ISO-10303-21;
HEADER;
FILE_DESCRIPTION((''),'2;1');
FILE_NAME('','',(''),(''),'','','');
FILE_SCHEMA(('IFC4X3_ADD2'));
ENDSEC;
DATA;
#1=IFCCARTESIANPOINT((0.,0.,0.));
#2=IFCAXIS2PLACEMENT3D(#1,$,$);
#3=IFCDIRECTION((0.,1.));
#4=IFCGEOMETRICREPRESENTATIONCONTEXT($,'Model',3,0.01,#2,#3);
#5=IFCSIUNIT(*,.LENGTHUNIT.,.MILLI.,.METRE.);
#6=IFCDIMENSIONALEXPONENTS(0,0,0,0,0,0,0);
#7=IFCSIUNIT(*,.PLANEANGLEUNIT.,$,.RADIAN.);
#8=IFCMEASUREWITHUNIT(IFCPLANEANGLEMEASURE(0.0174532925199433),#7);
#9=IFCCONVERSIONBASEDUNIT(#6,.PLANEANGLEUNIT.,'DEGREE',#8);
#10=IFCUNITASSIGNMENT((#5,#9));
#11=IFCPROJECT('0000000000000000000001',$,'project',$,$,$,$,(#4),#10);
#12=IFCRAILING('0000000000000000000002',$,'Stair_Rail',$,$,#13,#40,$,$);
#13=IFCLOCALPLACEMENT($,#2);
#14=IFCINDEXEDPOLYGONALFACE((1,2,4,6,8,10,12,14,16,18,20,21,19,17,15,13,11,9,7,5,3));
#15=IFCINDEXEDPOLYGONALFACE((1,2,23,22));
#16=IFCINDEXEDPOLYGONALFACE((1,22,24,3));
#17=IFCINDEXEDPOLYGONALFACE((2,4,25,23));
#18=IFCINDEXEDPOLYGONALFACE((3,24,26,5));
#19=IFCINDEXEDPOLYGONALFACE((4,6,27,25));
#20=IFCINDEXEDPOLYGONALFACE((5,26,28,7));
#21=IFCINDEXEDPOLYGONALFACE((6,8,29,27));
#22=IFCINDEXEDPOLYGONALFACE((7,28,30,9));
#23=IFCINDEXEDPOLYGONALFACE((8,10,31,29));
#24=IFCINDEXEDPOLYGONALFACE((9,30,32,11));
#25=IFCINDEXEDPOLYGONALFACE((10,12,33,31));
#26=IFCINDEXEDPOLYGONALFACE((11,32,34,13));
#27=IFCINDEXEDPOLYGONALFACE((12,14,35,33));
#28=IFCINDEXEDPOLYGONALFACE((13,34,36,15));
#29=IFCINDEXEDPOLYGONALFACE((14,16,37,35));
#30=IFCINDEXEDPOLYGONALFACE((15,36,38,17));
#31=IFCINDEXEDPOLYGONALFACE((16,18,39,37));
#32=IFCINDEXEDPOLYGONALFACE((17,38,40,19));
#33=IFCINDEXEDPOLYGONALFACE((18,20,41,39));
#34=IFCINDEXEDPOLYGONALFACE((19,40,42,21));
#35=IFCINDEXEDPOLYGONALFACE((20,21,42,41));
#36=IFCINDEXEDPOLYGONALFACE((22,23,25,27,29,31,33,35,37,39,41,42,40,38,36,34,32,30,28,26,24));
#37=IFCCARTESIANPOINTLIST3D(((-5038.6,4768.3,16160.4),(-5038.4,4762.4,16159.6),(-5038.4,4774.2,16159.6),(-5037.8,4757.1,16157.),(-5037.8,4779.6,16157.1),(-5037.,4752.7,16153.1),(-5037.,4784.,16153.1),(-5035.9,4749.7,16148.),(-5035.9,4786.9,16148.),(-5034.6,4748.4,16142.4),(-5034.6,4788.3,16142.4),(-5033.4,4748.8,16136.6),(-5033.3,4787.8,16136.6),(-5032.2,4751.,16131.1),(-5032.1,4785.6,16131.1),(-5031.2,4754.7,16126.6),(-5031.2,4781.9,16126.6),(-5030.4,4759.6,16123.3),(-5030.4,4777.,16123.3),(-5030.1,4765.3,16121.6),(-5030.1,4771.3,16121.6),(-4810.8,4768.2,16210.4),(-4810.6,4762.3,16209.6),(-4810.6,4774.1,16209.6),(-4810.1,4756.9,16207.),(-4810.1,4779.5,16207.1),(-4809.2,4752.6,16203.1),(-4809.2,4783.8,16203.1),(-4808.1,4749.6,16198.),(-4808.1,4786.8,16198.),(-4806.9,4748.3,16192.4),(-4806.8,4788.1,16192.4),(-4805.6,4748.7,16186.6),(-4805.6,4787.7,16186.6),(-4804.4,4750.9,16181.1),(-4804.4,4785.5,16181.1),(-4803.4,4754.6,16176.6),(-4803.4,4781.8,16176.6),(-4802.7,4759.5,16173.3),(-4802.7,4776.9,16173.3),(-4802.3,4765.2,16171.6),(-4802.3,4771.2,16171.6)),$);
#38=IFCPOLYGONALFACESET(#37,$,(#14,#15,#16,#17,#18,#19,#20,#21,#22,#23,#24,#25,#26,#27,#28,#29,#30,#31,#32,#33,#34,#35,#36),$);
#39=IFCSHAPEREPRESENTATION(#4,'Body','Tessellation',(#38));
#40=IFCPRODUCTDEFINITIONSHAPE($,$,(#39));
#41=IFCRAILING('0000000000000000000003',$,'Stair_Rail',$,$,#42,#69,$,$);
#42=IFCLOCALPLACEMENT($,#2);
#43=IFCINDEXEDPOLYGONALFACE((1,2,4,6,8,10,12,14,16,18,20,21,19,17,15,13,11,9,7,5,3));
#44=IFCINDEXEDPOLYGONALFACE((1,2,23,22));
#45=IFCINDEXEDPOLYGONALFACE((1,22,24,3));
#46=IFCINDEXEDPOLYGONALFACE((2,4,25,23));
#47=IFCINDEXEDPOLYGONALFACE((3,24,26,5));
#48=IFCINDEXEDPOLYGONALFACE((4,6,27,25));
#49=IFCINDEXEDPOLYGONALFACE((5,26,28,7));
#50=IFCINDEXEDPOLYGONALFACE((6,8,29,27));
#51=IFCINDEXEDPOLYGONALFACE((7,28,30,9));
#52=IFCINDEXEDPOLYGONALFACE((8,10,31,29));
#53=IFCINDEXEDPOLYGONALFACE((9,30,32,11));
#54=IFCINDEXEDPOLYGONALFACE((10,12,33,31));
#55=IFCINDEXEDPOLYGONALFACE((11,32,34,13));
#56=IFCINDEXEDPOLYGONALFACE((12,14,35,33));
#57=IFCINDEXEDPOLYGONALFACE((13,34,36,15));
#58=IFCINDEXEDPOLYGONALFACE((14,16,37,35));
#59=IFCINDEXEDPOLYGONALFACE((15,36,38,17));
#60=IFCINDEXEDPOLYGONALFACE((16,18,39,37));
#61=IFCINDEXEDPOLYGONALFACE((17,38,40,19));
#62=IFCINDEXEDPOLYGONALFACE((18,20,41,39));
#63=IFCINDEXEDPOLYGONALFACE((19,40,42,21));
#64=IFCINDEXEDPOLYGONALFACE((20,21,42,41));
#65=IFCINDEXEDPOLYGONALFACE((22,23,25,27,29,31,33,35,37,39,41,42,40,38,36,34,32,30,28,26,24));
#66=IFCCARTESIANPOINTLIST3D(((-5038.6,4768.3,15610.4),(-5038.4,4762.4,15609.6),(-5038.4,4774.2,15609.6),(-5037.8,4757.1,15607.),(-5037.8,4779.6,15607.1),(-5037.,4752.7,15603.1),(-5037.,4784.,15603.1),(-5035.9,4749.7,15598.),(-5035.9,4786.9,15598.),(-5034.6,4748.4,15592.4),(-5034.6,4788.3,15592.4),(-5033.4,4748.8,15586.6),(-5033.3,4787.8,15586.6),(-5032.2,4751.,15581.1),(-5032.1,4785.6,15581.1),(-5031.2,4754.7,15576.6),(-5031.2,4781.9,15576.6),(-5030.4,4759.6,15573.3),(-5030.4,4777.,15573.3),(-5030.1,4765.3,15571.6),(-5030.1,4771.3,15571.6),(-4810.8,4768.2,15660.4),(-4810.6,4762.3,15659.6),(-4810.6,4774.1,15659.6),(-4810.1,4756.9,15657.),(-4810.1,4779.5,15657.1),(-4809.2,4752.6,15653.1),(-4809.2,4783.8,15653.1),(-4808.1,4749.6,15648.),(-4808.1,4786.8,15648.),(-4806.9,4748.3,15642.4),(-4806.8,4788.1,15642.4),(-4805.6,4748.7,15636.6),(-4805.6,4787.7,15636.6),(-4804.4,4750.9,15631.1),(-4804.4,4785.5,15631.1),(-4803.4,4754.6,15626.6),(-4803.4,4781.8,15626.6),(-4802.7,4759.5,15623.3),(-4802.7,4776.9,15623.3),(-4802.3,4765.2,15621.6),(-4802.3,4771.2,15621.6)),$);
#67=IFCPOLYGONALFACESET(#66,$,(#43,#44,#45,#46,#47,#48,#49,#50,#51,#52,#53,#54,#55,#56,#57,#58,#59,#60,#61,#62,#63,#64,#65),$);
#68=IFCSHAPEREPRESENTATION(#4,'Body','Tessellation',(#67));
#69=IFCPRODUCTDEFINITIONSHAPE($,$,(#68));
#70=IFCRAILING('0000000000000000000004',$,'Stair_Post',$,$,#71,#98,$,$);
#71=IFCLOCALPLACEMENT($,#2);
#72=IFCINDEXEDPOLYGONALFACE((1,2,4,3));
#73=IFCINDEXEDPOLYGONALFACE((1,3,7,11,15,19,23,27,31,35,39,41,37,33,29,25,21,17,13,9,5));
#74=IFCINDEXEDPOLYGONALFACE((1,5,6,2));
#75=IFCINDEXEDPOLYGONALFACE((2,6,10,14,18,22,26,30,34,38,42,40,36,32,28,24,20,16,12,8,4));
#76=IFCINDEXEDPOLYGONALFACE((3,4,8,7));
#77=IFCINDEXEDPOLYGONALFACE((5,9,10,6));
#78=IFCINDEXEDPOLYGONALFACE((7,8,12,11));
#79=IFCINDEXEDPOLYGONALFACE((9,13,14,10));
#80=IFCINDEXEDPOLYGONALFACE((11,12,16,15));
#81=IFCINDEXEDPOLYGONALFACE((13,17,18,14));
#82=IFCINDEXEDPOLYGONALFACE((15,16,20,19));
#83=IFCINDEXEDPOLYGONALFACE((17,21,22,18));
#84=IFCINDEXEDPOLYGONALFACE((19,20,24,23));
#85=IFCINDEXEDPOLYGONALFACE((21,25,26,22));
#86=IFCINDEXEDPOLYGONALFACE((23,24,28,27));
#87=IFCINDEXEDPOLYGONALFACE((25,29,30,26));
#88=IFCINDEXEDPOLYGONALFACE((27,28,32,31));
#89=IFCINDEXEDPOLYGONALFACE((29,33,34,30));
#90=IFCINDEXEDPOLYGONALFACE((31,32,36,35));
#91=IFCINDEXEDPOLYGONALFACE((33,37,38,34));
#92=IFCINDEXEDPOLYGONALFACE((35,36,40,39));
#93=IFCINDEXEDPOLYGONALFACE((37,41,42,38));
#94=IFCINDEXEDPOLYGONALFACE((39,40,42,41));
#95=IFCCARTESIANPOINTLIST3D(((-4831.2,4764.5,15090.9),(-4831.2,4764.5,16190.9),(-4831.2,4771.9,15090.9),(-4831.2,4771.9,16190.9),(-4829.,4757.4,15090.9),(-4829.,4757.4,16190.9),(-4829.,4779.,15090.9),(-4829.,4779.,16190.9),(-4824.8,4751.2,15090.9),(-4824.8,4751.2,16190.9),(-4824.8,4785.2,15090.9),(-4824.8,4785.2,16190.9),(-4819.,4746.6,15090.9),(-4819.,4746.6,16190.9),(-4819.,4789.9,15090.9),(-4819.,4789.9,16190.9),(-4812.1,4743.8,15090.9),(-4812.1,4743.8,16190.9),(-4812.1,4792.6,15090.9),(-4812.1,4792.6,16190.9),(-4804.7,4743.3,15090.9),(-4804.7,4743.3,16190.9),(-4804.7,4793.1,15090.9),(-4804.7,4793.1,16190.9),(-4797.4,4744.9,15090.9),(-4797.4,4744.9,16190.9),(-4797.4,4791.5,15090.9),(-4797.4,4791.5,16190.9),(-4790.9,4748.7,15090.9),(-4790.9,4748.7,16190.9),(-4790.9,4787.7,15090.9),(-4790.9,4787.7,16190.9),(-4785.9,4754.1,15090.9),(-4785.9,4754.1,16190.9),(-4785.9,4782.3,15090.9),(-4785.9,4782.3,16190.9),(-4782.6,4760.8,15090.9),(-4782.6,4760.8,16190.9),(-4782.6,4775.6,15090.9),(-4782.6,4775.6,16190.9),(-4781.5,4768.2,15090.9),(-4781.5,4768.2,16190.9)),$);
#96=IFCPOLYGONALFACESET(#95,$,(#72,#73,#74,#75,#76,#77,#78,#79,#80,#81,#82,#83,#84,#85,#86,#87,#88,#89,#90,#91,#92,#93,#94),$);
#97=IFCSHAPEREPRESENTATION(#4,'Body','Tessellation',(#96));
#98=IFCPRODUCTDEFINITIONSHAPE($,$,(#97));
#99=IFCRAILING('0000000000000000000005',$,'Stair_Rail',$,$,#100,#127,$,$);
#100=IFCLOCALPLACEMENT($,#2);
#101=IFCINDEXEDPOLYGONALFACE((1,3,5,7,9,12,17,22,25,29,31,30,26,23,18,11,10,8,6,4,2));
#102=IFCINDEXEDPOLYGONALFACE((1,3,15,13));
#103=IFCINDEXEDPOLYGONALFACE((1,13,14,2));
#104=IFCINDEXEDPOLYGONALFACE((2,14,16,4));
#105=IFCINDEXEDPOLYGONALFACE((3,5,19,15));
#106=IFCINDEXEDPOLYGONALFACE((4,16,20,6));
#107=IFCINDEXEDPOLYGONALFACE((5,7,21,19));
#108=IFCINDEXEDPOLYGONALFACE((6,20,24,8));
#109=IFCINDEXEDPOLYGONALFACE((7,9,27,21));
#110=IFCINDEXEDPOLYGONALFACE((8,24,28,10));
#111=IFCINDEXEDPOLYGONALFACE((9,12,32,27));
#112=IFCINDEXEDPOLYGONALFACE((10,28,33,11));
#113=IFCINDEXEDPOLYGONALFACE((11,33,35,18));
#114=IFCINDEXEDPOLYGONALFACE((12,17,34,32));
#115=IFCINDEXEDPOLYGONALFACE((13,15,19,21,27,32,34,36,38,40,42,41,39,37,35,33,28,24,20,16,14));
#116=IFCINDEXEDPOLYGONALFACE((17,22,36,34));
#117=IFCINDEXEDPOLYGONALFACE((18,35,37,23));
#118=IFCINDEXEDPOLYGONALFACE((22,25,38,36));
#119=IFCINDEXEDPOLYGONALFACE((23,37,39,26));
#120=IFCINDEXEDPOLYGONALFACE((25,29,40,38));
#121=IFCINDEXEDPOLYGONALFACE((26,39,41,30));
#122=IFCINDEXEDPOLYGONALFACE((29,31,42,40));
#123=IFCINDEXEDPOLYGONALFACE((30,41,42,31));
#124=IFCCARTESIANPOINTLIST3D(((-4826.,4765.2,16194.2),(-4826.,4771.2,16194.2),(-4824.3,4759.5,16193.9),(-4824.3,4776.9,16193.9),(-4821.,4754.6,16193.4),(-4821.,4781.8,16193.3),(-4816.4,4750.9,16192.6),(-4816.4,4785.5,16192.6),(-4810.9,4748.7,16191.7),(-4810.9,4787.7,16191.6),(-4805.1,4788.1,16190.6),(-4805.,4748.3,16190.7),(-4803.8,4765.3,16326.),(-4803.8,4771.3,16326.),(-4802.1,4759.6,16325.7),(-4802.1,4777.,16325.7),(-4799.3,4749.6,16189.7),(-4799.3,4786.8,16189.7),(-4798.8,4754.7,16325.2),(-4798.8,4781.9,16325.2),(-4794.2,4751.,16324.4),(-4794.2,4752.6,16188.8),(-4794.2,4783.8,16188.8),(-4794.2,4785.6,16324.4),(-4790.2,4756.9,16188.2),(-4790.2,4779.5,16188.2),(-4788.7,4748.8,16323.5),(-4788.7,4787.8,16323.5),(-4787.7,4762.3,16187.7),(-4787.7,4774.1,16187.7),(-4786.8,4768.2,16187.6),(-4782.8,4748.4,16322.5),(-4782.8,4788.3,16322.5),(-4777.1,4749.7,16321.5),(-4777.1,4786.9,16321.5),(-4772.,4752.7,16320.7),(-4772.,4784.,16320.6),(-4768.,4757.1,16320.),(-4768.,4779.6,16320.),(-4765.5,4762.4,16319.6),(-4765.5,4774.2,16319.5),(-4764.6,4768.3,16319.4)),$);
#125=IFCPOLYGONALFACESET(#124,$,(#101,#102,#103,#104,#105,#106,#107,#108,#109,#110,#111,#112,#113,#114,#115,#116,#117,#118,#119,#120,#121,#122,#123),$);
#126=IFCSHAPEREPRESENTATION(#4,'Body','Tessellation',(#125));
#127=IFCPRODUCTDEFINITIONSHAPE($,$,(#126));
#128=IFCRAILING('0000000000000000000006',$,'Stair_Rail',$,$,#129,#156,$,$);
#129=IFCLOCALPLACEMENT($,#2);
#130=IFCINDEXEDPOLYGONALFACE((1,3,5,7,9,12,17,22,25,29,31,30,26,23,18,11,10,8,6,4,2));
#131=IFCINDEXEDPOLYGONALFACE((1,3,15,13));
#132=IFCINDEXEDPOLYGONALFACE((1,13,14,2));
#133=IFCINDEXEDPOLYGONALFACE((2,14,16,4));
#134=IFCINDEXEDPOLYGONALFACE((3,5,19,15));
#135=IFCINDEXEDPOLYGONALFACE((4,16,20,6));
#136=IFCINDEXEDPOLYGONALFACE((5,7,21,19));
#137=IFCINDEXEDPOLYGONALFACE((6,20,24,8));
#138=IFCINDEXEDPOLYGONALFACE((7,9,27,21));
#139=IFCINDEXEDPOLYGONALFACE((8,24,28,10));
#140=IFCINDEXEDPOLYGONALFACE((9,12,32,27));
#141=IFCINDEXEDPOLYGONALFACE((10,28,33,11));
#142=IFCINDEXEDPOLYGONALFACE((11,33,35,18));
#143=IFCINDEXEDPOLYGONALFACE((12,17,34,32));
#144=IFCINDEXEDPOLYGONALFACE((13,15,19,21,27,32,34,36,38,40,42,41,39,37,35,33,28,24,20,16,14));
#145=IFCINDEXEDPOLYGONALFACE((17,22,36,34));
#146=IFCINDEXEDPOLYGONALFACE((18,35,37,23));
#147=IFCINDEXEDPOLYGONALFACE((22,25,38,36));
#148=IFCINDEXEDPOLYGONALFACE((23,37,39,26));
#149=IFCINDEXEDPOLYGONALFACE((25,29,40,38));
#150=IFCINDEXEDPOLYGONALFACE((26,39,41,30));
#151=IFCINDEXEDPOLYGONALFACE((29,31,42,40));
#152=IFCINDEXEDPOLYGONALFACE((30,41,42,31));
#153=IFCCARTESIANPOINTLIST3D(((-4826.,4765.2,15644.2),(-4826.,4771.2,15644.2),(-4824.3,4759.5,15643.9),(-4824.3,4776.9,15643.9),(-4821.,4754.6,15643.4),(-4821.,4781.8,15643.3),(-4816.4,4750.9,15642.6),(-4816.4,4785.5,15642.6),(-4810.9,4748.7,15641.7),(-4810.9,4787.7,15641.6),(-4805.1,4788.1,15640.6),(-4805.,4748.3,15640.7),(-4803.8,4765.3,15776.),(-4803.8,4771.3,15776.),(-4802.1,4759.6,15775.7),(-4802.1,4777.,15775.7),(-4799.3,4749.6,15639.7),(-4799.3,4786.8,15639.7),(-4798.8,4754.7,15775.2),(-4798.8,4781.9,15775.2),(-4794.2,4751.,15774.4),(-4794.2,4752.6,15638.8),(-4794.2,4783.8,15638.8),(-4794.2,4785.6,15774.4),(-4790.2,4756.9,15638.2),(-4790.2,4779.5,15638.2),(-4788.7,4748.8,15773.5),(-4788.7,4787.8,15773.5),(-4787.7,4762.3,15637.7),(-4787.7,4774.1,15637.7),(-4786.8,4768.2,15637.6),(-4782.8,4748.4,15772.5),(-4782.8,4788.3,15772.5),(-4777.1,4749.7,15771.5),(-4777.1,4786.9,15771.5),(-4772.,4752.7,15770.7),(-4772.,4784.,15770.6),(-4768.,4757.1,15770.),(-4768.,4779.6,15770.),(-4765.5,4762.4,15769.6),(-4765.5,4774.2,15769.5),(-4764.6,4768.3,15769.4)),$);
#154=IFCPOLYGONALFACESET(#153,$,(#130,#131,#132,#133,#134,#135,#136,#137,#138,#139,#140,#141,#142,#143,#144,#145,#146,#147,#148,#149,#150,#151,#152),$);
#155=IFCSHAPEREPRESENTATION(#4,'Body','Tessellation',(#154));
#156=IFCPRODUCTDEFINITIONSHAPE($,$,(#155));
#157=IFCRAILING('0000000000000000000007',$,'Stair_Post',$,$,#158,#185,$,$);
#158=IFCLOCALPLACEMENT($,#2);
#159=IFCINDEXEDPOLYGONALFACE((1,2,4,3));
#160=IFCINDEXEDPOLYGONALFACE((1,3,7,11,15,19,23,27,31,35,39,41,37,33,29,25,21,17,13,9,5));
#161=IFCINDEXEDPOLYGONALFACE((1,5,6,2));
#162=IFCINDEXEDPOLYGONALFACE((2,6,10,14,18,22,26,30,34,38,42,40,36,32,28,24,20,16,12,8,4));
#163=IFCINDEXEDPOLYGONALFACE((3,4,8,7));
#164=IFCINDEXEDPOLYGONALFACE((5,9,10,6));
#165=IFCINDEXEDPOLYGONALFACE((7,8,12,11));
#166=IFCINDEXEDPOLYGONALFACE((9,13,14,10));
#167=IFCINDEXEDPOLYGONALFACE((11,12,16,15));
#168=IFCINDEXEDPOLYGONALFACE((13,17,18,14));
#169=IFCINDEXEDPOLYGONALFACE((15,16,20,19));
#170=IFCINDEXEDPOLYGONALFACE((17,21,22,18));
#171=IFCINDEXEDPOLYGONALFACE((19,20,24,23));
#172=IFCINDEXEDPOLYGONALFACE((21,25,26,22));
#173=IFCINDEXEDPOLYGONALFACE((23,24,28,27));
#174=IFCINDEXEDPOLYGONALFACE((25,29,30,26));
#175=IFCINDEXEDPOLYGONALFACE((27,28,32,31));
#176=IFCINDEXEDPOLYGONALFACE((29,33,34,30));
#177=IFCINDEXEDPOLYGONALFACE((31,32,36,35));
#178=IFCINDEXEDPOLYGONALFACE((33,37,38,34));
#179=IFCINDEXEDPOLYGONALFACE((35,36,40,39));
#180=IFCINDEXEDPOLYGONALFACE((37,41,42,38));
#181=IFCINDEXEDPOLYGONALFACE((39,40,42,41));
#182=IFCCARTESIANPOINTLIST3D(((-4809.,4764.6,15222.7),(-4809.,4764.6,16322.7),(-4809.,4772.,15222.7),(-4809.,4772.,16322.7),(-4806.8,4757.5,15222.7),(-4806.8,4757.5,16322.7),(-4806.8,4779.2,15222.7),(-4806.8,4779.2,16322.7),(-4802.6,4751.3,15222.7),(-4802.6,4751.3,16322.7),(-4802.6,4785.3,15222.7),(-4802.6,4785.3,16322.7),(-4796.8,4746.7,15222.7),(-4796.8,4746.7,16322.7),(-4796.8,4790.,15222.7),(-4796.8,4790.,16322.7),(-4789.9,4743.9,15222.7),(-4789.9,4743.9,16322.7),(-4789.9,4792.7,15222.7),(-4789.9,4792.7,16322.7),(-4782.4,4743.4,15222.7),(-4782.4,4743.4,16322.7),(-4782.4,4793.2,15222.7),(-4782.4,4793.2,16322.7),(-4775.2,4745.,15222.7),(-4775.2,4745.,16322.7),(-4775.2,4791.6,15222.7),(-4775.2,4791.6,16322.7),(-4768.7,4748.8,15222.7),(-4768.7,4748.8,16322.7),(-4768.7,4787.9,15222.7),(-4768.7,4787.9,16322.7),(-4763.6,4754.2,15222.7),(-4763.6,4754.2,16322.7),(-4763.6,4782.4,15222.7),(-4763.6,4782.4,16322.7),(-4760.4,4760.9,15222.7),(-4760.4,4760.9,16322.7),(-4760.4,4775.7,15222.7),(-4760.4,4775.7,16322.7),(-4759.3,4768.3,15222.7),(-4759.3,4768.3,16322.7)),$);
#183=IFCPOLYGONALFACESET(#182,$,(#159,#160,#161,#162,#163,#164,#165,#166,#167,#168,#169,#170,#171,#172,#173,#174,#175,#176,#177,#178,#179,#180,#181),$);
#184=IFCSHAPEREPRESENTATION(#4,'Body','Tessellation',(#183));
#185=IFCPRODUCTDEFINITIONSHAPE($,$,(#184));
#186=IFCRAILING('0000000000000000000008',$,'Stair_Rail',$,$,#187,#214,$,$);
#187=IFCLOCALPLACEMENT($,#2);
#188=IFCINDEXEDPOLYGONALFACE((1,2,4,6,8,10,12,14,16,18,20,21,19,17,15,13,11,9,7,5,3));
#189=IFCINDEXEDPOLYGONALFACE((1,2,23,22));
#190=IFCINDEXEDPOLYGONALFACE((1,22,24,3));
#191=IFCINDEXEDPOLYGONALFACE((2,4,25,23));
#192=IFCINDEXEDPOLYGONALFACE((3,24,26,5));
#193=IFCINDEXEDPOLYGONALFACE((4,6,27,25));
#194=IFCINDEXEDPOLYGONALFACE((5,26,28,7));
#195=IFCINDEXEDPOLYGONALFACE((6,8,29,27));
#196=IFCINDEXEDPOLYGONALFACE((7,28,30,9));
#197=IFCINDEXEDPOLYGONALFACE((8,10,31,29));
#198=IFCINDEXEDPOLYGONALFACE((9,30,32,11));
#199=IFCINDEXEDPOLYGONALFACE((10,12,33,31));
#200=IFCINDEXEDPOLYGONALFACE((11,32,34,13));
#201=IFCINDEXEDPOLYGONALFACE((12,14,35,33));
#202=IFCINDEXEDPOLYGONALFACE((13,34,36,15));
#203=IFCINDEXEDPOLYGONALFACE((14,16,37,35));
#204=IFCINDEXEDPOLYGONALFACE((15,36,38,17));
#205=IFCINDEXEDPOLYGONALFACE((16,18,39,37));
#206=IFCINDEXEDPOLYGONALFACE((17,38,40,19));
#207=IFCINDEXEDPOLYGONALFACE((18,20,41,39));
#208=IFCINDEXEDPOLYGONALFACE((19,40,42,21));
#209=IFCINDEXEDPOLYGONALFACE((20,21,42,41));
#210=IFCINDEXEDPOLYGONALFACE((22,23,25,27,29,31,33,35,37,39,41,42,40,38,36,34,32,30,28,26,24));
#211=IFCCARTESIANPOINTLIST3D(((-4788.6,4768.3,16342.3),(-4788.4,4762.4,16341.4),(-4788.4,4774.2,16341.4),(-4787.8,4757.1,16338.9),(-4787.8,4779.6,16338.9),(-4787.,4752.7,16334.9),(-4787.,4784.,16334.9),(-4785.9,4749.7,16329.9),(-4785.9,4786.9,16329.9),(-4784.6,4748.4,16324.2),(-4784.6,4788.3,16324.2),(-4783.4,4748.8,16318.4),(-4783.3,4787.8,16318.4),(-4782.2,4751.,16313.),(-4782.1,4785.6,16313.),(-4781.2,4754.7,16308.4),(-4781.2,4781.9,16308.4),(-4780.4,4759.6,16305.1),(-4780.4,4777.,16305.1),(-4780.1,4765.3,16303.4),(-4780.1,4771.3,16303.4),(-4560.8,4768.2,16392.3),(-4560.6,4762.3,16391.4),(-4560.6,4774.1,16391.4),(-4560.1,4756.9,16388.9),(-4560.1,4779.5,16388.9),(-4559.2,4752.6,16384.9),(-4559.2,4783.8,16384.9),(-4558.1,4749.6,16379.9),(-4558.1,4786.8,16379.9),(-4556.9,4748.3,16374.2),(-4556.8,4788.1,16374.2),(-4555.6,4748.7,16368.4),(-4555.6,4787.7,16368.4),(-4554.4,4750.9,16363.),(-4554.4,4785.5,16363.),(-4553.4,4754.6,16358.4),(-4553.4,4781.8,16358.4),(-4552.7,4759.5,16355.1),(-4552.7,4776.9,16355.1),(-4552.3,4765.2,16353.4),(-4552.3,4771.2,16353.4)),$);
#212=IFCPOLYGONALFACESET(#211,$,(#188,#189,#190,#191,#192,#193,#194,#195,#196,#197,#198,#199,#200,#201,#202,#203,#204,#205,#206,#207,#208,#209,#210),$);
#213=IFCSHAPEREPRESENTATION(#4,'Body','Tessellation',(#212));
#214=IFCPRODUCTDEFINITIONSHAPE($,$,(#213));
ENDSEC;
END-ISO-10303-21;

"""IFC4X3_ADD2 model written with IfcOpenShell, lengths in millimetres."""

from ifc_helpers import new_model, entity, si_unit, converted_unit, direction, frame, origin, context, project, circle, extrude, element, save


model = new_model("IFC4X3_ADD2")

# Units and contexts
model_context = context("Model", 3, precision=0.01, world=origin(), true_north=direction((0.0, 1.0)))
ifc_project = project(units=[si_unit("LENGTHUNIT", "METRE", prefix="MILLI"), converted_unit("PLANEANGLEUNIT", "DEGREE", entity("IfcPlaneAngleMeasure", 0.0174532925199433), si_unit("PLANEANGLEUNIT", "RADIAN"), dimensions=[0, 0, 0, 0, 0, 0, 0])], contexts=[model_context])

# Railings
element("IfcRailing", 1, Name="Stair_Rail", context=model_context, shape_type="SweptSolid", body=[
    entity("IfcSweptDiskSolid", entity("IfcPolyline", [entity("IfcCartesianPoint", [-5034.3, 4768.3, 16140.9]), entity("IfcCartesianPoint", [-4806.5, 4768.2, 16190.9])]), 20.0),
])
element("IfcRailing", 2, Name="Stair_Rail", context=model_context, shape_type="SweptSolid", body=[
    entity("IfcSweptDiskSolid", entity("IfcPolyline", [entity("IfcCartesianPoint", [-5034.3, 4768.3, 15590.9]), entity("IfcCartesianPoint", [-4806.5, 4768.2, 15640.9])]), 20.0),
])
element("IfcRailing", 3, Name="Stair_Post", context=model_context, shape_type="SweptSolid", body=[
    extrude(circle(Radius=25.0), frame((-4806.5, 4768.2, 15090.9)), (0.0, 0.0, 1.0), 1100.0),
])
element("IfcRailing", 4, Name="Stair_Rail", context=model_context, shape_type="SweptSolid", body=[
    entity("IfcSweptDiskSolid", entity("IfcPolyline", [entity("IfcCartesianPoint", [-4806.5, 4768.2, 16190.9]), entity("IfcCartesianPoint", [-4784.3, 4768.3, 16322.7])]), 20.0),
])
element("IfcRailing", 5, Name="Stair_Rail", context=model_context, shape_type="SweptSolid", body=[
    entity("IfcSweptDiskSolid", entity("IfcPolyline", [entity("IfcCartesianPoint", [-4806.5, 4768.2, 15640.9]), entity("IfcCartesianPoint", [-4784.3, 4768.3, 15772.7])]), 20.0),
])
element("IfcRailing", 6, Name="Stair_Post", context=model_context, shape_type="SweptSolid", body=[
    extrude(circle(Radius=25.0), frame((-4784.3, 4768.3, 15222.7)), (0.0, 0.0, 1.0), 1100.0),
])
element("IfcRailing", 7, Name="Stair_Rail", context=model_context, shape_type="SweptSolid", body=[
    entity("IfcSweptDiskSolid", entity("IfcPolyline", [entity("IfcCartesianPoint", [-4784.3, 4768.3, 16322.7]), entity("IfcCartesianPoint", [-4556.5, 4768.2, 16372.7])]), 20.0),
])

save(model, "model.ifc")
